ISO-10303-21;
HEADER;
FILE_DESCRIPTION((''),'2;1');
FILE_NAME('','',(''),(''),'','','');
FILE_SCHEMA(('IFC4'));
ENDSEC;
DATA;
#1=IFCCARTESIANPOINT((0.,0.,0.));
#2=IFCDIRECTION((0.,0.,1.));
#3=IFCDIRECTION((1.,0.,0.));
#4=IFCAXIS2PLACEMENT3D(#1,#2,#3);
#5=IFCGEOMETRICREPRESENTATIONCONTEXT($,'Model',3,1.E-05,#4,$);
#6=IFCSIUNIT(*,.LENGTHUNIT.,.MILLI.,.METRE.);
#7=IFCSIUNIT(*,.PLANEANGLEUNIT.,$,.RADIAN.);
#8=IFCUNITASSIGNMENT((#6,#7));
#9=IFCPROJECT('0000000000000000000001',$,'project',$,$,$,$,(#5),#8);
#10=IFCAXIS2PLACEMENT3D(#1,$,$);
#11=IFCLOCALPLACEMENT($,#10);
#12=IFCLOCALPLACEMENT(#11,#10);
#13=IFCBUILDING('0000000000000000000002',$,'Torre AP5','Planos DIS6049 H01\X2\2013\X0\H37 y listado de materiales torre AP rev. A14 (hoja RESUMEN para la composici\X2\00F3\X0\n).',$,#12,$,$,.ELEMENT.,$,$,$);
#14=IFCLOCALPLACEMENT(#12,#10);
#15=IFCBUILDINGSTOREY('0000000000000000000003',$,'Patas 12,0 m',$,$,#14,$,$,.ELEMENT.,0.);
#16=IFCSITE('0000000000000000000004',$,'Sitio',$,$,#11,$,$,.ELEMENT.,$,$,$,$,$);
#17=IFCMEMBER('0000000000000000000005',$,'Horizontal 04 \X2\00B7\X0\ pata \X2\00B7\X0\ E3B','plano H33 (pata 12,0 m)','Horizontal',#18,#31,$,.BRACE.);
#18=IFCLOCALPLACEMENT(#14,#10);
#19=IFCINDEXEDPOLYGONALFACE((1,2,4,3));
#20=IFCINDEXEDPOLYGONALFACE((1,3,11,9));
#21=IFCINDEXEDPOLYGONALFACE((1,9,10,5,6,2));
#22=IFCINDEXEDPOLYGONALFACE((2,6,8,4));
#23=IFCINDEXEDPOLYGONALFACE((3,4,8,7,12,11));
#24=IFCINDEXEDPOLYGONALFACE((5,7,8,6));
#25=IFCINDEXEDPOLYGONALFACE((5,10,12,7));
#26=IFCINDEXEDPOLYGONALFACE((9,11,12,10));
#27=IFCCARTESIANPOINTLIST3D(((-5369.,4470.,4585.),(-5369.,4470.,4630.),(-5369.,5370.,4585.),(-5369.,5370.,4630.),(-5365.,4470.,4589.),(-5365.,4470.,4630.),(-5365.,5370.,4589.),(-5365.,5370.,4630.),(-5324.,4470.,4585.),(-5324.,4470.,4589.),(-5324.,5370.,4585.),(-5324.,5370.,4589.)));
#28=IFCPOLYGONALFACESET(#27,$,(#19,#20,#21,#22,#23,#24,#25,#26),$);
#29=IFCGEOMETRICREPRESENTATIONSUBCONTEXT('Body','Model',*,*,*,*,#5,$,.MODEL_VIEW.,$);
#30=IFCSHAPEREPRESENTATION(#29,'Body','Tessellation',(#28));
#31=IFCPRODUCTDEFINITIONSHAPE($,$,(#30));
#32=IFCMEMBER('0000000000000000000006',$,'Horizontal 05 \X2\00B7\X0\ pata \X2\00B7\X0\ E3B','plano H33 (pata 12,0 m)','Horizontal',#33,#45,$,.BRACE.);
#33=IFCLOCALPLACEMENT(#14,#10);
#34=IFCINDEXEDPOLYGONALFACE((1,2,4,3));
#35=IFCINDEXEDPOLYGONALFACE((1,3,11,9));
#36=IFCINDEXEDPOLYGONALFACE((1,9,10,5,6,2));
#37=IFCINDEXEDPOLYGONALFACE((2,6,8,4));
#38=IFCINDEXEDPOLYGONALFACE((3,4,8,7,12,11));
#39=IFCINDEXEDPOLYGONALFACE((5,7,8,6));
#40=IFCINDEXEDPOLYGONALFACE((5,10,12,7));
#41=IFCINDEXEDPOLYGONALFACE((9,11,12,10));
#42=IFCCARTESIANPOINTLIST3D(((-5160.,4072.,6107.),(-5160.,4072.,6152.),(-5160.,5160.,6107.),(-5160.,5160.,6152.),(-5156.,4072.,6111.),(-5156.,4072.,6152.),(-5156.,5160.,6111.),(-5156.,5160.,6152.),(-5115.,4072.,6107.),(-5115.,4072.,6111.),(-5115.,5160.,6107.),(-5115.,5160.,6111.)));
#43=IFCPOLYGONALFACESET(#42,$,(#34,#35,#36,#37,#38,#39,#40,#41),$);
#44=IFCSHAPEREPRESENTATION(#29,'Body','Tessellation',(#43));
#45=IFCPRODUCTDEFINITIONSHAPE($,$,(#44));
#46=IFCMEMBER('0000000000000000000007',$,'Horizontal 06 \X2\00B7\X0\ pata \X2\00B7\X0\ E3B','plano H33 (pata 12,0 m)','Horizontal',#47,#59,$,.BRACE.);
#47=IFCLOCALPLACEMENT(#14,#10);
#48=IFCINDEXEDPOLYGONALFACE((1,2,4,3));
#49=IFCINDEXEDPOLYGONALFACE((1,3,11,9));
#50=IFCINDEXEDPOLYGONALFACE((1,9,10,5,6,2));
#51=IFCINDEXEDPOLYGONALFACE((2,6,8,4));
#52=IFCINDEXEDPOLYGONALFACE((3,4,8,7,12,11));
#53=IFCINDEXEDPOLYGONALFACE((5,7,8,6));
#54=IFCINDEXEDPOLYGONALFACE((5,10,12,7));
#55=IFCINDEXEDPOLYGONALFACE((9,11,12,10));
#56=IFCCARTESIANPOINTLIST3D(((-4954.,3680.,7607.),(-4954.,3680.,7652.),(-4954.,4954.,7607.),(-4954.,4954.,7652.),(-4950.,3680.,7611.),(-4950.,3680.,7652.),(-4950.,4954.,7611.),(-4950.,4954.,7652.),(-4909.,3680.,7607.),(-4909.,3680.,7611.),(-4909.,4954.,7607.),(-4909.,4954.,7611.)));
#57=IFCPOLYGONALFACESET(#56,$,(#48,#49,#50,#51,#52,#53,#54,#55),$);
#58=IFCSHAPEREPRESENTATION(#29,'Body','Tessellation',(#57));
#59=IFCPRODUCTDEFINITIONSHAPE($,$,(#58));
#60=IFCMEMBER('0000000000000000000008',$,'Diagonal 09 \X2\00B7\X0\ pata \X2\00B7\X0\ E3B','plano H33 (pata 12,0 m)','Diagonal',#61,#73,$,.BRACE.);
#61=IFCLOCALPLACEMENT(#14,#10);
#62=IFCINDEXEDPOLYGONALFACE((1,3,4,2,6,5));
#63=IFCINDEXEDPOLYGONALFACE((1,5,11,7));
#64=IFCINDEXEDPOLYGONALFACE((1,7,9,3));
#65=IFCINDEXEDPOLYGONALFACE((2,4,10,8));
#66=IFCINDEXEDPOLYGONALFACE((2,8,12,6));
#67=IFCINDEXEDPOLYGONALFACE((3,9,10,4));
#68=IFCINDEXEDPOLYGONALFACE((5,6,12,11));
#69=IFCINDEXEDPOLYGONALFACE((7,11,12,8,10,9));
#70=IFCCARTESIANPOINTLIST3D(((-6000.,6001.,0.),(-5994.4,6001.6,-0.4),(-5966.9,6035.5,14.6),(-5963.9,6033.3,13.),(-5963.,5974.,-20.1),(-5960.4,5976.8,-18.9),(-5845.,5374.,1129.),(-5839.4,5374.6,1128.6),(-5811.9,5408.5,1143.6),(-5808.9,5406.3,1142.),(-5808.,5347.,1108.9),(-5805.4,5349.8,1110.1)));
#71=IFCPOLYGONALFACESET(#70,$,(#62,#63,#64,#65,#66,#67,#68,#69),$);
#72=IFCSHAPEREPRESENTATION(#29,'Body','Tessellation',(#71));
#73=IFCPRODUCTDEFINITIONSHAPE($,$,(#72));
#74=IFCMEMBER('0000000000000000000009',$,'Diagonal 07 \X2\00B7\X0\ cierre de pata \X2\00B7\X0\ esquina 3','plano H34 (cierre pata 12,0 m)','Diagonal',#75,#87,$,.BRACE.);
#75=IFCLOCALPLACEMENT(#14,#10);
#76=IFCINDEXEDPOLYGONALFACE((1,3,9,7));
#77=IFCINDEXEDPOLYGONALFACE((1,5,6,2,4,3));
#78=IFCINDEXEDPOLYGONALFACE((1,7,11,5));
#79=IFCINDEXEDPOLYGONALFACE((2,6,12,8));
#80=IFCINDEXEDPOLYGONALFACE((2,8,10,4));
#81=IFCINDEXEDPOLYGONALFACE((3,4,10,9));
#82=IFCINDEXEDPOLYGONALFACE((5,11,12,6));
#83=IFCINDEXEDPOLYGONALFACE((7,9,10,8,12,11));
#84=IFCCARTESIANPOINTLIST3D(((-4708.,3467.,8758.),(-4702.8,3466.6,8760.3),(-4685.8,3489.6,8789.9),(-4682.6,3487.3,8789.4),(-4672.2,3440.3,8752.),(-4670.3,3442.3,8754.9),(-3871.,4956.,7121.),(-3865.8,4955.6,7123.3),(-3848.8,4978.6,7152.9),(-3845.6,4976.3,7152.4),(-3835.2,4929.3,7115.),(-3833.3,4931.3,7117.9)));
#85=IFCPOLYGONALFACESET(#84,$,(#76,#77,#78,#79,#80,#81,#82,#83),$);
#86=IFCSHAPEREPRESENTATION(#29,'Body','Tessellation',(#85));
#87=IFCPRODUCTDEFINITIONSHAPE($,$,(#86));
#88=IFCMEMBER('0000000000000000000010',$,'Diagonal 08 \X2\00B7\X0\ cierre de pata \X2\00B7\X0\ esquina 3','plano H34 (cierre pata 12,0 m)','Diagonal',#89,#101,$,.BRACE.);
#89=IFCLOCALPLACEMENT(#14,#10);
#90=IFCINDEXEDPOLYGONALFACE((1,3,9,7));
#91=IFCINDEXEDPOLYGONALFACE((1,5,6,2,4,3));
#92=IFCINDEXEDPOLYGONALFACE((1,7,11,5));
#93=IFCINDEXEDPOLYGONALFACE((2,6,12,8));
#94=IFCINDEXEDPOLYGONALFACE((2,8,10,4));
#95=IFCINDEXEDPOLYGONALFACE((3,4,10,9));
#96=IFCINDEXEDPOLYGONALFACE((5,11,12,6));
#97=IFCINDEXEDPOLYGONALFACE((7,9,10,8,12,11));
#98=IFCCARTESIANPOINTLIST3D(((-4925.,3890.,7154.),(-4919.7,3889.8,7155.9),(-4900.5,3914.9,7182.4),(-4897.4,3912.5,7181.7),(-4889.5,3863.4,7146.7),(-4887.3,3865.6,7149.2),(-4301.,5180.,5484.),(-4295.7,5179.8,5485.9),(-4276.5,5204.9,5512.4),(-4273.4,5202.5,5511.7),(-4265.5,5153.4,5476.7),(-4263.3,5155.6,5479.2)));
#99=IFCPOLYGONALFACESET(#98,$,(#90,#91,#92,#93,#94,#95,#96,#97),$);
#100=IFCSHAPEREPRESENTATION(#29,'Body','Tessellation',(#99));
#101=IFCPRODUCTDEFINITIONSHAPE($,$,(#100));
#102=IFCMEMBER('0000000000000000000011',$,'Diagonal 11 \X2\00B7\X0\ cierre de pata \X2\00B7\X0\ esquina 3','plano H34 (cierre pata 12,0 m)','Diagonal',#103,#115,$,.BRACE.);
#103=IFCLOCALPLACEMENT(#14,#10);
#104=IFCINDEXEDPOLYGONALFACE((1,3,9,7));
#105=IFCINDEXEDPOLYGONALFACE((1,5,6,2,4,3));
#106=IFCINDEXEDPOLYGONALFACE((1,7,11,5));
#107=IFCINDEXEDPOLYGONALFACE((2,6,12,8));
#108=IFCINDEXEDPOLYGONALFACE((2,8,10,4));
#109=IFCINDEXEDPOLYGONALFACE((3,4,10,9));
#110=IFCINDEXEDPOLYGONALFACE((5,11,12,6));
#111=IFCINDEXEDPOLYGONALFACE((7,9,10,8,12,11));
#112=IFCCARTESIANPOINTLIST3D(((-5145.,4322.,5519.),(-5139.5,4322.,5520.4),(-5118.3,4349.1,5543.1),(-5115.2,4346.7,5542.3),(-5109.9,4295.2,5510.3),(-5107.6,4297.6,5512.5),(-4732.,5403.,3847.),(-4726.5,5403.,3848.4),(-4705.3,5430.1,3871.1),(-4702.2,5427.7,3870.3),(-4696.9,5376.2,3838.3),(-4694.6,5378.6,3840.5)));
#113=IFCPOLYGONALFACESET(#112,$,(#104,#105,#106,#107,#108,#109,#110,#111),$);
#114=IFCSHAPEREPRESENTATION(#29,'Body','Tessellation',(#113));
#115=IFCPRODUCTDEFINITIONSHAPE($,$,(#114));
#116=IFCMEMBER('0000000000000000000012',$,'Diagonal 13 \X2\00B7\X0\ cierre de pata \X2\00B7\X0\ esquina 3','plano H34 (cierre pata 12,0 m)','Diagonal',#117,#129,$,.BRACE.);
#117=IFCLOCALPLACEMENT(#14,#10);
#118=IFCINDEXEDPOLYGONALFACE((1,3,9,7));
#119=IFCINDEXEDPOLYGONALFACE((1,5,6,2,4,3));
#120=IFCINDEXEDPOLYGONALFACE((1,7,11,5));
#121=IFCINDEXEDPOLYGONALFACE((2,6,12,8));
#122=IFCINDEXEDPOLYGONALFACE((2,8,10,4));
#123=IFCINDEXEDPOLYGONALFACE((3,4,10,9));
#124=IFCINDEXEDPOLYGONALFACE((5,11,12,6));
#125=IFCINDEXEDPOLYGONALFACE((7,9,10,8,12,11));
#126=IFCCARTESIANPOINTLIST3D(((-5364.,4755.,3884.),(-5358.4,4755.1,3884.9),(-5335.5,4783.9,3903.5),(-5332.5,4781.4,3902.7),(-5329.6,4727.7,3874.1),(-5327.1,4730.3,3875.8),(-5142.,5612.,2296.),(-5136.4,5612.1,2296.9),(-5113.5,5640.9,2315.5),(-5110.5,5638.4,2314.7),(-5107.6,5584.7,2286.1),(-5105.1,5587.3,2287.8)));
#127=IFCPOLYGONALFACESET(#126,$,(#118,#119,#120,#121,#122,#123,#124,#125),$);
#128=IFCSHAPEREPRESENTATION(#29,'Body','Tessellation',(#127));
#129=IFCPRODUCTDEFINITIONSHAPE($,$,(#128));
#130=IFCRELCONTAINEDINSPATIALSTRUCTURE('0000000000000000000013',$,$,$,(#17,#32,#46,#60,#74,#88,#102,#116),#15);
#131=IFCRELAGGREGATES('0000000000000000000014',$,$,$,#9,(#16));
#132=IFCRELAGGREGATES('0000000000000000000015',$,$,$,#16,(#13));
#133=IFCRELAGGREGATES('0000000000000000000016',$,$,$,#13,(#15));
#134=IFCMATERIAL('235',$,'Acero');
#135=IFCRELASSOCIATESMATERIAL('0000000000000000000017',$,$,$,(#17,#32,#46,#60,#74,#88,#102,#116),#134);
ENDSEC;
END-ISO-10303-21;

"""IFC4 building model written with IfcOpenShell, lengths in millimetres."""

from ifc_helpers import new_model, si_unit, frame, frame_2d, origin, origin_with_axes, place, context, subcontext, project, spatial, l_section, extrude, material, element, save


model = new_model("IFC4")

# Units and contexts
model_context = context("Model", 3, precision=1e-05, world=origin_with_axes())
body_context = subcontext(model_context, "Body", "Model", "MODEL_VIEW")
ifc_project = project(units=[si_unit("LENGTHUNIT", "METRE", prefix="MILLI"), si_unit("PLANEANGLEUNIT", "RADIAN")], contexts=[model_context])

# Site, building, storey
site_placement = place(None, origin())
site = spatial("IfcSite", under=ifc_project, at=site_placement, Name="Sitio", CompositionType="ELEMENT")
building_placement = place(site_placement, origin())
building = spatial("IfcBuilding", under=site, at=building_placement, Name="Torre AP5", Description="Planos DIS6049 H01–H37 y listado de materiales torre AP rev. A14 (hoja RESUMEN para la composición).", CompositionType="ELEMENT")
storey_placement = place(building_placement, origin())
storey = spatial("IfcBuildingStorey", under=building, at=storey_placement, Name="Patas 12,0 m", CompositionType="ELEMENT", Elevation=0.0)

# Members
ifc_material_1 = material(Name="235", Category="Acero")
member_1_placement = place(storey_placement, frame((-5369.0, 5370.0, 4585.0), z_axis=(0.0, -1.0, 0.0), x_axis=(1.0, 0.0, 0.0)))
element("IfcMember", 1, at=member_1_placement, inside=storey, material=ifc_material_1, Name="Horizontal 04 · pata · E3B", Description="plano H33 (pata 12,0 m)", ObjectType="Horizontal", PredefinedType="BRACE", context=body_context, shape_type="SweptSolid", body=[
    extrude(l_section(Depth=45.0, Width=45.0, Thickness=4.0, at=frame_2d((22.5, 22.5))), None, (0.0, 0.0, 1.0), 900.0),
])
member_2_placement = place(storey_placement, frame((-5160.0, 5160.0, 6107.0), z_axis=(0.0, -1.0, 0.0), x_axis=(1.0, 0.0, 0.0)))
element("IfcMember", 2, at=member_2_placement, inside=storey, material=ifc_material_1, Name="Horizontal 05 · pata · E3B", Description="plano H33 (pata 12,0 m)", ObjectType="Horizontal", PredefinedType="BRACE", context=body_context, shape_type="SweptSolid", body=[
    extrude(l_section(Depth=45.0, Width=45.0, Thickness=4.0, at=frame_2d((22.5, 22.5))), None, (0.0, 0.0, 1.0), 1088.0),
])
member_3_placement = place(storey_placement, frame((-4954.0, 4954.0, 7607.0), z_axis=(0.0, -1.0, 0.0), x_axis=(1.0, 0.0, 0.0)))
element("IfcMember", 3, at=member_3_placement, inside=storey, material=ifc_material_1, Name="Horizontal 06 · pata · E3B", Description="plano H33 (pata 12,0 m)", ObjectType="Horizontal", PredefinedType="BRACE", context=body_context, shape_type="SweptSolid", body=[
    extrude(l_section(Depth=45.0, Width=45.0, Thickness=4.0, at=frame_2d((22.5, 22.5))), None, (0.0, 0.0, 1.0), 1274.0),
])
member_4_placement = place(storey_placement, frame((-6000.0, 6001.0, 0.0), z_axis=(0.119168, -0.482052, 0.868001), x_axis=(0.73958, -0.54018, -0.40153)))
element("IfcMember", 4, at=member_4_placement, inside=storey, material=ifc_material_1, Name="Diagonal 09 · pata · E3B", Description="plano H33 (pata 12,0 m)", ObjectType="Diagonal", PredefinedType="BRACE", context=body_context, shape_type="SweptSolid", body=[
    extrude(l_section(Depth=50.0, Width=50.0, Thickness=4.0, at=frame_2d((25.0, 25.0))), None, (0.0, 0.0, 1.0), 1300.7),
])
member_5_placement = place(storey_placement, frame((-3871.0, 4956.0, 7121.0), z_axis=(-0.353777, -0.62936, 0.691916), x_axis=(0.794484, -0.592588, -0.132792)))
element("IfcMember", 5, at=member_5_placement, inside=storey, material=ifc_material_1, Name="Diagonal 07 · cierre de pata · esquina 3", Description="plano H34 (cierre pata 12,0 m)", ObjectType="Diagonal", PredefinedType="BRACE", context=body_context, shape_type="SweptSolid", body=[
    extrude(l_section(Depth=45.0, Width=45.0, Thickness=4.0, at=frame_2d((22.5, 22.5))), None, (0.0, 0.0, 1.0), 2365.9),
])
member_6_placement = place(storey_placement, frame((-4301.0, 5180.0, 5484.0), z_axis=(-0.283567, -0.58622, 0.758905), x_axis=(0.789705, -0.591712, -0.161995)))
element("IfcMember", 6, at=member_6_placement, inside=storey, material=ifc_material_1, Name="Diagonal 08 · cierre de pata · esquina 3", Description="plano H34 (cierre pata 12,0 m)", ObjectType="Diagonal", PredefinedType="BRACE", context=body_context, shape_type="SweptSolid", body=[
    extrude(l_section(Depth=45.0, Width=45.0, Thickness=4.0, at=frame_2d((22.5, 22.5))), None, (0.0, 0.0, 1.0), 2200.5),
])
member_7_placement = place(storey_placement, frame((-4732.0, 5403.0, 3847.0), z_axis=(-0.203108, -0.531622, 0.822268), x_axis=(0.779508, -0.595989, -0.192779)))
element("IfcMember", 7, at=member_7_placement, inside=storey, material=ifc_material_1, Name="Diagonal 11 · cierre de pata · esquina 3", Description="plano H34 (cierre pata 12,0 m)", ObjectType="Diagonal", PredefinedType="BRACE", context=body_context, shape_type="SweptSolid", body=[
    extrude(l_section(Depth=45.0, Width=45.0, Thickness=4.0, at=frame_2d((22.5, 22.5))), None, (0.0, 0.0, 1.0), 2033.4),
])
member_8_placement = place(storey_placement, frame((-5142.0, 5612.0, 2296.0), z_axis=(-0.122106, -0.471372, 0.873441), x_axis=(0.764761, -0.605619, -0.219923)))
element("IfcMember", 8, at=member_8_placement, inside=storey, material=ifc_material_1, Name="Diagonal 13 · cierre de pata · esquina 3", Description="plano H34 (cierre pata 12,0 m)", ObjectType="Diagonal", PredefinedType="BRACE", context=body_context, shape_type="SweptSolid", body=[
    extrude(l_section(Depth=45.0, Width=45.0, Thickness=4.0, at=frame_2d((22.5, 22.5))), None, (0.0, 0.0, 1.0), 1818.1),
])

save(model, "model.ifc")
